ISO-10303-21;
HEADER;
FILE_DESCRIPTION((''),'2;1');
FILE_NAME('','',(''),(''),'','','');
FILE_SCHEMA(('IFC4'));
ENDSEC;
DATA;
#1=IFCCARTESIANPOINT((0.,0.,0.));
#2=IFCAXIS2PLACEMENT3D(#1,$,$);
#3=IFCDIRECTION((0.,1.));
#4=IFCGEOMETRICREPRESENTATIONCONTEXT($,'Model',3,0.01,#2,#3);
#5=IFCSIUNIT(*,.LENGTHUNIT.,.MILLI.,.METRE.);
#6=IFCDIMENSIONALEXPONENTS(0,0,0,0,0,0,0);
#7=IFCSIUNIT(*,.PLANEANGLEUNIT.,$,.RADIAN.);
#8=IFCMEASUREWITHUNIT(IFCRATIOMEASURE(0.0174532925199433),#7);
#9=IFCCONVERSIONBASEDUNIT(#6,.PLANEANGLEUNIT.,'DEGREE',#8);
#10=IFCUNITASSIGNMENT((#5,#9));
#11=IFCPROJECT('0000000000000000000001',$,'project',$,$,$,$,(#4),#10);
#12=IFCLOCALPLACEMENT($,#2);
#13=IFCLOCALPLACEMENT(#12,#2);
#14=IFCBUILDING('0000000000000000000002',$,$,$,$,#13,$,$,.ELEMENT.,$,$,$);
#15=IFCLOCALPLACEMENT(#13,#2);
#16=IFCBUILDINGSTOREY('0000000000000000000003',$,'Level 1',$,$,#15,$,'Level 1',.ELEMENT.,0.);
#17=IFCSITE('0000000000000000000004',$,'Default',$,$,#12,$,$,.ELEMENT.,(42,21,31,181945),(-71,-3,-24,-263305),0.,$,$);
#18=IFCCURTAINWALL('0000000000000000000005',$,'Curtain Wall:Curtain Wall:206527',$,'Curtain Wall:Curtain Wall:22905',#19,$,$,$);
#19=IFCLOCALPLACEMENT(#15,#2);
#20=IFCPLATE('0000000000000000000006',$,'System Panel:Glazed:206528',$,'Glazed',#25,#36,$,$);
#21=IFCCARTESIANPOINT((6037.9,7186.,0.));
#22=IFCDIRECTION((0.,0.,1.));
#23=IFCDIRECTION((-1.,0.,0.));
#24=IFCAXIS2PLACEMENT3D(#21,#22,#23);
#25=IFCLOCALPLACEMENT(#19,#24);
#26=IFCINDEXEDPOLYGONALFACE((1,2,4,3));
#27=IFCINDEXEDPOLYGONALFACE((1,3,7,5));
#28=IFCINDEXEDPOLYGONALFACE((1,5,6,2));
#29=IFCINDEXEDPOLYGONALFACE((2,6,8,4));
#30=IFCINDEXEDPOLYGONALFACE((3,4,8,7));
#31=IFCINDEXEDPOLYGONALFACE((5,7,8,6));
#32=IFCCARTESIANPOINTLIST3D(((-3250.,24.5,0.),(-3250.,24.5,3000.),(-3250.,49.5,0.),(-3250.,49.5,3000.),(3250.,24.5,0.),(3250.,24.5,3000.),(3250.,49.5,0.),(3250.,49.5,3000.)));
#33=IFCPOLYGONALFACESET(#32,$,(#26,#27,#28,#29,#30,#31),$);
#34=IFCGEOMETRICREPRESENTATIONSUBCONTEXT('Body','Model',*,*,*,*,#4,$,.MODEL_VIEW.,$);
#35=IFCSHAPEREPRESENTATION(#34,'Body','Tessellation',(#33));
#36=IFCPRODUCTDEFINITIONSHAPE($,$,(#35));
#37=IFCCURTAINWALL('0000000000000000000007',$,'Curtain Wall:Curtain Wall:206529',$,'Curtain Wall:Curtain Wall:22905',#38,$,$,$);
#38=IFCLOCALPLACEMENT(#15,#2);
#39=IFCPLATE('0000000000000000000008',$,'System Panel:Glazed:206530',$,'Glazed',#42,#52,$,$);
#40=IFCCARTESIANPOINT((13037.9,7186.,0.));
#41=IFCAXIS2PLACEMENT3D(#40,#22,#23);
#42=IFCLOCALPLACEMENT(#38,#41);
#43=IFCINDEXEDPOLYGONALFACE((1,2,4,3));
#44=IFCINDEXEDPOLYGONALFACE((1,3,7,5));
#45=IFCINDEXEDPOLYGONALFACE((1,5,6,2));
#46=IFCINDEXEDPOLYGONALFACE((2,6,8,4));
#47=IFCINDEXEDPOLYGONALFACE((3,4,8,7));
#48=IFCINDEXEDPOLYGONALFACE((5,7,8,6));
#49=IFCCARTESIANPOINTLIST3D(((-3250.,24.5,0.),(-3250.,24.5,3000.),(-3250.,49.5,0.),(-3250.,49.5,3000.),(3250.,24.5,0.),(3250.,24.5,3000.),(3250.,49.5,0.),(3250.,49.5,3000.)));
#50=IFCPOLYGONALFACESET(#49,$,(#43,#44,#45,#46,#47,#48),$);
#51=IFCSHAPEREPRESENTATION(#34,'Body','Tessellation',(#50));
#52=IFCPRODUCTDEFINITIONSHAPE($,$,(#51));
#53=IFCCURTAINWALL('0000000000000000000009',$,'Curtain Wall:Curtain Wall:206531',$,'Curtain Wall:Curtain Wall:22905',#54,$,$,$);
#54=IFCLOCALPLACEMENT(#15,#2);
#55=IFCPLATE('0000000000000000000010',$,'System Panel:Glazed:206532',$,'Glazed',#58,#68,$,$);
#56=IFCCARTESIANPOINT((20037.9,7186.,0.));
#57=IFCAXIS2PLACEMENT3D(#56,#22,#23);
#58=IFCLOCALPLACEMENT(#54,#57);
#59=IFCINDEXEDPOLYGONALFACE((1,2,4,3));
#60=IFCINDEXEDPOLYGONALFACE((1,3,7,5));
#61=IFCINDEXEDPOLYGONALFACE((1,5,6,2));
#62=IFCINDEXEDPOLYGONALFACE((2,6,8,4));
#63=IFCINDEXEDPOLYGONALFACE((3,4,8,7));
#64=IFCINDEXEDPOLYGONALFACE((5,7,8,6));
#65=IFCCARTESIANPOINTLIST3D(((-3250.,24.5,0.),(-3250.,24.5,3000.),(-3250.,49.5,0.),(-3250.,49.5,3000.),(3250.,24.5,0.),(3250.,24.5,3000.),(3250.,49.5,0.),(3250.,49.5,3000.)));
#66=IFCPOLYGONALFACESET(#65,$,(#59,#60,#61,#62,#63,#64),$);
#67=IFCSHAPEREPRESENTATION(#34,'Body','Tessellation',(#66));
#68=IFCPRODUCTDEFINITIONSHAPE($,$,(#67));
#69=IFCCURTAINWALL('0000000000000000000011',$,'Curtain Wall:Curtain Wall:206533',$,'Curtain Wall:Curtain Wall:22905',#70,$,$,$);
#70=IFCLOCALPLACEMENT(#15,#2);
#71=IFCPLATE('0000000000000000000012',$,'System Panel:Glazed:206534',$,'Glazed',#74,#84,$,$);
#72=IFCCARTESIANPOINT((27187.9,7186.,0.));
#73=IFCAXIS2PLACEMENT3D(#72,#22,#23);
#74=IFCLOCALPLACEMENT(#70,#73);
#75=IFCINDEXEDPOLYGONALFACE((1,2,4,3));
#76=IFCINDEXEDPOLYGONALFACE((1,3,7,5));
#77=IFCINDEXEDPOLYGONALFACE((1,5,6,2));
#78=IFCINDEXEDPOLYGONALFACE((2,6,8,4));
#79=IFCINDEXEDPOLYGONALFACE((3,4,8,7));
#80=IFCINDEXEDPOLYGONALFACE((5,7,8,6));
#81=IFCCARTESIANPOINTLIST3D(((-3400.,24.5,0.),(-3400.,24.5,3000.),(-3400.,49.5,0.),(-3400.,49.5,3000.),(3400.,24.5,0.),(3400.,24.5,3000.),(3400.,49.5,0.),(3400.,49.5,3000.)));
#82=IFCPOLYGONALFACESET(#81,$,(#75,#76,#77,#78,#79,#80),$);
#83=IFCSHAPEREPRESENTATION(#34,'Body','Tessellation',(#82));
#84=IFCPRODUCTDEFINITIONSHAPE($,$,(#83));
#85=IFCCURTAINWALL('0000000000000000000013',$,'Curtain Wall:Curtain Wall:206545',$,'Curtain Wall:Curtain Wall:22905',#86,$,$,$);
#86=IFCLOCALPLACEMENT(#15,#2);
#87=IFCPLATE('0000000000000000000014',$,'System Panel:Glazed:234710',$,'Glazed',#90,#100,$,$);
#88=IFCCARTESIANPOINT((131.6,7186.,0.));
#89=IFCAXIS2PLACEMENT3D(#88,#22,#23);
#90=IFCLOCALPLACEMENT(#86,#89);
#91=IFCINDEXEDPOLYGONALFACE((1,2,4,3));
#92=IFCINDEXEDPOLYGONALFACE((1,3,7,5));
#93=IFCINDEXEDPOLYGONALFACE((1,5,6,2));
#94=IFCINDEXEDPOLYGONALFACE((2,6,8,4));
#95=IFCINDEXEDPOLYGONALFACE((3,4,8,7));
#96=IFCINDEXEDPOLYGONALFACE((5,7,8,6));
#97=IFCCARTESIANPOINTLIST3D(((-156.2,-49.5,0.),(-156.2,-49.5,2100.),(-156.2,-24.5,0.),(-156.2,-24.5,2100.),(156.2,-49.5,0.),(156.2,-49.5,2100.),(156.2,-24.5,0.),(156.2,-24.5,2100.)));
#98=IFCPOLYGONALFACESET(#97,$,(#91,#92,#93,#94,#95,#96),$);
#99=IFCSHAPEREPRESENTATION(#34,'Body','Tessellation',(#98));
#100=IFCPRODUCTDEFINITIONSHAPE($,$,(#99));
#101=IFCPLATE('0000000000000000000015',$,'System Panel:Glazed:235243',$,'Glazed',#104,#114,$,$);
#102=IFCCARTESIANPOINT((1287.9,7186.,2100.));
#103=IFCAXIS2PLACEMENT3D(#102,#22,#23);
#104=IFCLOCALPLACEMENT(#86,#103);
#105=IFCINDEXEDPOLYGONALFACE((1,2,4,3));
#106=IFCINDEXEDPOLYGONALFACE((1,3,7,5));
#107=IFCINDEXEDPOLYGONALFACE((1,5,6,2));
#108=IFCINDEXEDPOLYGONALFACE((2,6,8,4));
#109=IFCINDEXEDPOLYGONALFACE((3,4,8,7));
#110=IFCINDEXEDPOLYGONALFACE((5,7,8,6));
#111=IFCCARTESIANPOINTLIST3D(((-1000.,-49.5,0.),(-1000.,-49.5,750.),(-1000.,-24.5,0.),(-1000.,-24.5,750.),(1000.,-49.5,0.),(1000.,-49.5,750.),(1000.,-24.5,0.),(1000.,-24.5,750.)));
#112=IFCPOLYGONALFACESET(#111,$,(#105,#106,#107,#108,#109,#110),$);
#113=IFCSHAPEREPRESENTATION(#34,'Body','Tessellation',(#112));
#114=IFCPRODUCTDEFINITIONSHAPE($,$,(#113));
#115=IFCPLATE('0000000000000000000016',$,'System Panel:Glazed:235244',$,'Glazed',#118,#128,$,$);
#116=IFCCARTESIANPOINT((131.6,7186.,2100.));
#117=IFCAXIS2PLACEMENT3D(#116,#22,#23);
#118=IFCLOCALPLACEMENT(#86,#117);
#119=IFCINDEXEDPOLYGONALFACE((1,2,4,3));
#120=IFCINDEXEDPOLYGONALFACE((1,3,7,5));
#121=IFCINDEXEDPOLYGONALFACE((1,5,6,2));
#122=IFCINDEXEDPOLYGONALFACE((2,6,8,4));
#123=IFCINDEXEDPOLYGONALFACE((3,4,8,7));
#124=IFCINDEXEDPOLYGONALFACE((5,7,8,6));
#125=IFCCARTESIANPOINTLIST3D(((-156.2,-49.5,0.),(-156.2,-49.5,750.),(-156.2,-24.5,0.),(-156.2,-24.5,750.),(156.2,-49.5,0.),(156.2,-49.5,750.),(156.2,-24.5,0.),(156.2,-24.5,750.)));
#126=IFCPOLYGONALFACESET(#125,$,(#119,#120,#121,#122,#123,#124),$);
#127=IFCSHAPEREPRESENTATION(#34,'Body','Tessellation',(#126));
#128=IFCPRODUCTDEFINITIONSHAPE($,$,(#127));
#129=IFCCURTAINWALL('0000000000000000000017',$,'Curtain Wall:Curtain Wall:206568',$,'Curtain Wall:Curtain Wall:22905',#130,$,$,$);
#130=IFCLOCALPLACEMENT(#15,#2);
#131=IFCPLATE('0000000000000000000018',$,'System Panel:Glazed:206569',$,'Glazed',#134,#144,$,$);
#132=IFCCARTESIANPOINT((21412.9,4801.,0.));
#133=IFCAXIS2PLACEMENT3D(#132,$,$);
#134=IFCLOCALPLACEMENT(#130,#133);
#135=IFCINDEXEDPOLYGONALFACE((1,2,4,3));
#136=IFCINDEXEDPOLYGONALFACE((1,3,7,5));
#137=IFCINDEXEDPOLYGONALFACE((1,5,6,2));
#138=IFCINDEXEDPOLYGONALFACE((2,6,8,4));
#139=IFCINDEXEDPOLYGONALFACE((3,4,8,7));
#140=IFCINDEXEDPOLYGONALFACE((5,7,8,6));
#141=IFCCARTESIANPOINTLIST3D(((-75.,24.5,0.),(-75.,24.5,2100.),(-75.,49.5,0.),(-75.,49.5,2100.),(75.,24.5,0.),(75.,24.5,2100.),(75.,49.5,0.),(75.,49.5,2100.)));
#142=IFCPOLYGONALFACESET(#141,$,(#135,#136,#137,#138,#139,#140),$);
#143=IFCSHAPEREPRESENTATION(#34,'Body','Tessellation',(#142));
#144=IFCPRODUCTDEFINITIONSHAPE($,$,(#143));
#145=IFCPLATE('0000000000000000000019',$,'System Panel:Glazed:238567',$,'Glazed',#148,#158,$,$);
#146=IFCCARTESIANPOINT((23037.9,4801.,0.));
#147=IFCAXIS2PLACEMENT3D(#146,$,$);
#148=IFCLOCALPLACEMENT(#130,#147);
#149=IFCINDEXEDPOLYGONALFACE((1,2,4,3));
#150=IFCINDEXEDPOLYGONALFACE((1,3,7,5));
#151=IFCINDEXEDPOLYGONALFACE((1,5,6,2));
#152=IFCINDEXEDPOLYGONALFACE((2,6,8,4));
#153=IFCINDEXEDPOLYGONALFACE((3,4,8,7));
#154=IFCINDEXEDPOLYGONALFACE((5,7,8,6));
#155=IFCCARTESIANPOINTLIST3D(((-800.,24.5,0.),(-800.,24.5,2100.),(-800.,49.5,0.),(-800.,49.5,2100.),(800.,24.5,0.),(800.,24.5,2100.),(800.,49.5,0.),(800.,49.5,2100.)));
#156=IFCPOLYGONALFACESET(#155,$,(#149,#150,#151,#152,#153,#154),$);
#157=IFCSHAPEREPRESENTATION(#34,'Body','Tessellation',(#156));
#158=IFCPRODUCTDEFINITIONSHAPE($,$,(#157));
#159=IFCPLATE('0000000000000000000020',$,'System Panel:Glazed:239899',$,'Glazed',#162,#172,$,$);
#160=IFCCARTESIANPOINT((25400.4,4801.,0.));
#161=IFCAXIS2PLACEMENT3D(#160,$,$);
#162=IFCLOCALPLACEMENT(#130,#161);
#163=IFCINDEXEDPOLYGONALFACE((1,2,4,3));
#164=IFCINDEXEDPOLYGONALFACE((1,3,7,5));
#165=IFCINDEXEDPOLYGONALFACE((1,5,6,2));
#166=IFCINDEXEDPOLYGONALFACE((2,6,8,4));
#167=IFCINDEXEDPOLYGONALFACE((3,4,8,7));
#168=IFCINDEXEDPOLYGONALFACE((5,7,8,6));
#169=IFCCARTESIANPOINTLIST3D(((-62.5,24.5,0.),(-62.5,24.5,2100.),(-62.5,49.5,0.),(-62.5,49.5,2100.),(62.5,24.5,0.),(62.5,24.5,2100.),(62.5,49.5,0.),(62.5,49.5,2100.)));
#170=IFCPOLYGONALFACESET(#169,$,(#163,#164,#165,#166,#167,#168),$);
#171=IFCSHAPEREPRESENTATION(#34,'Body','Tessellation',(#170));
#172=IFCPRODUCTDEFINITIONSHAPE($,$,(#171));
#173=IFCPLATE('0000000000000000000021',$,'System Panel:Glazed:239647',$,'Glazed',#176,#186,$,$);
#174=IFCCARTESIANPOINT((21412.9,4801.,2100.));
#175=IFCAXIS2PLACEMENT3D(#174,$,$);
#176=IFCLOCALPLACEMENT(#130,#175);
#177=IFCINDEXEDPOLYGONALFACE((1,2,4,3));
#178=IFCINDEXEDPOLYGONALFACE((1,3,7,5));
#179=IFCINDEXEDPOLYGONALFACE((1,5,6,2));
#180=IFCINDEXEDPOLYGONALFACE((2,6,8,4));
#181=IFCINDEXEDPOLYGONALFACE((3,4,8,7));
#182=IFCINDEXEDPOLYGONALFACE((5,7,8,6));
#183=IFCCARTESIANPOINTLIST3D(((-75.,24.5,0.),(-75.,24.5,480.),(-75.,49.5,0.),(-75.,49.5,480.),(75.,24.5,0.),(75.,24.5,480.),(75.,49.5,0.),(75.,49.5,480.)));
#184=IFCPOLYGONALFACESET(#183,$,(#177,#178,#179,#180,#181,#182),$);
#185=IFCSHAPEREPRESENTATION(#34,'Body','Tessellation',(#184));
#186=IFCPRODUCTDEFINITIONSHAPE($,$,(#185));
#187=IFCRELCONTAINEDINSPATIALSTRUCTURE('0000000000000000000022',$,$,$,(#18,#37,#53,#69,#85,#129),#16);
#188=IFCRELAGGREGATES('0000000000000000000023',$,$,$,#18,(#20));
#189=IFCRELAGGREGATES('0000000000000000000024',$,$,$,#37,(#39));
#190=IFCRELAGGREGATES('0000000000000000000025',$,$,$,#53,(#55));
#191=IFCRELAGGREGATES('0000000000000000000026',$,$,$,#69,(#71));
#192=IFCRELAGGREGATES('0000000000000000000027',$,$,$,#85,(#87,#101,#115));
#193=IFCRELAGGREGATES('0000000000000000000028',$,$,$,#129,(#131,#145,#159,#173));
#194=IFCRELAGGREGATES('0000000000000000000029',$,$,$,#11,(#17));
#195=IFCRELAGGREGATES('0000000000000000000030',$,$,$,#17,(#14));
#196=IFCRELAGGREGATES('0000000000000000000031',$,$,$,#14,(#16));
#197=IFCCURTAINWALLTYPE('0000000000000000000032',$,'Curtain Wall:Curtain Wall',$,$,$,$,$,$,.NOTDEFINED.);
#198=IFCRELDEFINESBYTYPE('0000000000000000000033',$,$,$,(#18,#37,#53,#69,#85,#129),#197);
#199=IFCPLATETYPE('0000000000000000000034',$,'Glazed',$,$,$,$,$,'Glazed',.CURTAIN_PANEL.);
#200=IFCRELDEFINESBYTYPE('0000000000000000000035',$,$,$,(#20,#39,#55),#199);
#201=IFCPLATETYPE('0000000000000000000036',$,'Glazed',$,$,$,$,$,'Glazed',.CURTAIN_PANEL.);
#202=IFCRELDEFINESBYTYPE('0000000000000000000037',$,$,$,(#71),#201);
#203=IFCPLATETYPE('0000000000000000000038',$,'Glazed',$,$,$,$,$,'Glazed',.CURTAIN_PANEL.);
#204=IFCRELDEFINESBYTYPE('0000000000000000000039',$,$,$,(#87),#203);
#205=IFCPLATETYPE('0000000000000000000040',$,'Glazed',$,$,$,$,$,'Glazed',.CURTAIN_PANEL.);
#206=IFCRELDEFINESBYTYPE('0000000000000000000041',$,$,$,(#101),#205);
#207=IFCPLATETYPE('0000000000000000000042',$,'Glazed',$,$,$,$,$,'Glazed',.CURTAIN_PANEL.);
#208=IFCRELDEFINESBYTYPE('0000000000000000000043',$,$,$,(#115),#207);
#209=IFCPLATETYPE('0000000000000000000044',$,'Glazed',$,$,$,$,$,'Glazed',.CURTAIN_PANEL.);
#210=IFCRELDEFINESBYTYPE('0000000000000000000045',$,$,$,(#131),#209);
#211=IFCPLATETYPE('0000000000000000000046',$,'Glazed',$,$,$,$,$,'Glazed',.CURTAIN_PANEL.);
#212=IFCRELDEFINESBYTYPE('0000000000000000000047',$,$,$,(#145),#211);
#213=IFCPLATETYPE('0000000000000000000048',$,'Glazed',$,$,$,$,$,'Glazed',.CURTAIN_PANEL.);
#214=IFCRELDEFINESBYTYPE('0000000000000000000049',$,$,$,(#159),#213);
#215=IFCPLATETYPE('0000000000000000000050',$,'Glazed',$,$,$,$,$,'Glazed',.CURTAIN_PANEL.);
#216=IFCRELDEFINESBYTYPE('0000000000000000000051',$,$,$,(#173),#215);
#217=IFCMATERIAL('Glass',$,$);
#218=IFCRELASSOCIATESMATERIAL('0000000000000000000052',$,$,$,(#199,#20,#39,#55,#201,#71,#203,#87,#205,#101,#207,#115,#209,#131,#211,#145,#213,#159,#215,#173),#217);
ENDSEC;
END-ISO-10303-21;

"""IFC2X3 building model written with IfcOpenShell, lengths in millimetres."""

from ifc_helpers import new_model, entity, si_unit, converted_unit, direction, frame, frame_2d, origin, origin_2d_with_axis, place, context, subcontext, project, spatial, rectangle, extrude, source, transform, mapped, material, type_object, type_shapes, element, aggregate, save


model = new_model("IFC2X3")

# Units and contexts
model_context = context("Model", 3, precision=0.01, world=origin(), true_north=direction((0.0, 1.0)))
body_context = subcontext(model_context, "Body", "Model", "MODEL_VIEW")
ifc_project = project(units=[si_unit("LENGTHUNIT", "METRE", prefix="MILLI"), converted_unit("PLANEANGLEUNIT", "DEGREE", entity("IfcRatioMeasure", 0.0174532925199433), si_unit("PLANEANGLEUNIT", "RADIAN"), dimensions=[0, 0, 0, 0, 0, 0, 0])], contexts=[model_context])

# Site, building, storey
site_placement = place(None, origin())
site = spatial("IfcSite", under=ifc_project, at=site_placement, Name="Default", CompositionType="ELEMENT", RefLatitude=(42, 21, 31, 181945), RefLongitude=(-71, -3, -24, -263305), RefElevation=0.0)
building_placement = place(site_placement, origin())
building = spatial("IfcBuilding", under=site, at=building_placement, CompositionType="ELEMENT")
storey_placement = place(building_placement, origin())
storey = spatial("IfcBuildingStorey", under=building, at=storey_placement, Name="Level 1", LongName="Level 1", CompositionType="ELEMENT", Elevation=0.0)

# Curtain walls, plates
curtain_wall_type = type_object("IfcCurtainWallType", Name="Curtain Wall:Curtain Wall", PredefinedType="NOTDEFINED")
curtain_wall_1_placement = place(storey_placement, origin())
curtain_wall_1 = element("IfcCurtainWall", 1, at=curtain_wall_1_placement, inside=storey, type_object=curtain_wall_type, Name="Curtain Wall:Curtain Wall:206527", ObjectType="Curtain Wall:Curtain Wall:22905")
ifc_material_1 = material(Name="Glass")
plate_type_1 = type_object("IfcPlateType", Name="Glazed", ElementType="Glazed", PredefinedType="CURTAIN_PANEL", material=ifc_material_1)
shared_shape_1 = source(origin(), body_context, "Body", "SweptSolid", [
    extrude(rectangle(XDim=25.0, YDim=6500.0, at=origin_2d_with_axis()), frame((0.0, 37.0, 0.0), z_axis=(0.0, 0.0, 1.0), x_axis=(0.0, 1.0, 0.0)), (0.0, 0.0, 1.0), 3000.0),
])
type_shapes(plate_type_1, [shared_shape_1])
plate_1_placement = place(curtain_wall_1_placement, frame((6037.9, 7186.0, 0.0), z_axis=(0.0, 0.0, 1.0), x_axis=(-1.0, 0.0, 0.0)))
plate_1 = element("IfcPlate", 2, at=plate_1_placement, type_object=plate_type_1, material=ifc_material_1, Name="System Panel:Glazed:206528", ObjectType="Glazed", context=body_context, shape_type="MappedRepresentation", body=[
    mapped(shared_shape_1, transform((0.0, 0.0, 0.0), scale=1.0)),
])
aggregate(curtain_wall_1, [plate_1])
curtain_wall_2_placement = place(storey_placement, origin())
curtain_wall_2 = element("IfcCurtainWall", 3, at=curtain_wall_2_placement, inside=storey, type_object=curtain_wall_type, Name="Curtain Wall:Curtain Wall:206529", ObjectType="Curtain Wall:Curtain Wall:22905")
plate_2_placement = place(curtain_wall_2_placement, frame((13037.9, 7186.0, 0.0), z_axis=(0.0, 0.0, 1.0), x_axis=(-1.0, 0.0, 0.0)))
plate_2 = element("IfcPlate", 4, at=plate_2_placement, type_object=plate_type_1, material=ifc_material_1, Name="System Panel:Glazed:206530", ObjectType="Glazed", context=body_context, shape_type="MappedRepresentation", body=[
    mapped(shared_shape_1, transform((0.0, 0.0, 0.0), scale=1.0)),
])
aggregate(curtain_wall_2, [plate_2])
curtain_wall_3_placement = place(storey_placement, origin())
curtain_wall_3 = element("IfcCurtainWall", 5, at=curtain_wall_3_placement, inside=storey, type_object=curtain_wall_type, Name="Curtain Wall:Curtain Wall:206531", ObjectType="Curtain Wall:Curtain Wall:22905")
plate_3_placement = place(curtain_wall_3_placement, frame((20037.9, 7186.0, 0.0), z_axis=(0.0, 0.0, 1.0), x_axis=(-1.0, 0.0, 0.0)))
plate_3 = element("IfcPlate", 6, at=plate_3_placement, type_object=plate_type_1, material=ifc_material_1, Name="System Panel:Glazed:206532", ObjectType="Glazed", context=body_context, shape_type="MappedRepresentation", body=[
    mapped(shared_shape_1, transform((0.0, 0.0, 0.0), scale=1.0)),
])
aggregate(curtain_wall_3, [plate_3])
curtain_wall_4_placement = place(storey_placement, origin())
curtain_wall_4 = element("IfcCurtainWall", 7, at=curtain_wall_4_placement, inside=storey, type_object=curtain_wall_type, Name="Curtain Wall:Curtain Wall:206533", ObjectType="Curtain Wall:Curtain Wall:22905")
plate_type_2 = type_object("IfcPlateType", Name="Glazed", ElementType="Glazed", PredefinedType="CURTAIN_PANEL", material=ifc_material_1)
shared_shape_2 = source(origin(), body_context, "Body", "SweptSolid", [
    extrude(rectangle(XDim=25.0, YDim=6800.0, at=origin_2d_with_axis()), frame((0.0, 37.0, 0.0), z_axis=(0.0, 0.0, 1.0), x_axis=(0.0, 1.0, 0.0)), (0.0, 0.0, 1.0), 3000.0),
])
type_shapes(plate_type_2, [shared_shape_2])
plate_4_placement = place(curtain_wall_4_placement, frame((27187.9, 7186.0, 0.0), z_axis=(0.0, 0.0, 1.0), x_axis=(-1.0, 0.0, 0.0)))
plate_4 = element("IfcPlate", 8, at=plate_4_placement, type_object=plate_type_2, material=ifc_material_1, Name="System Panel:Glazed:206534", ObjectType="Glazed", context=body_context, shape_type="MappedRepresentation", body=[
    mapped(shared_shape_2, transform((0.0, 0.0, 0.0), scale=1.0)),
])
aggregate(curtain_wall_4, [plate_4])

# Curtain walls, plates
curtain_wall_5_placement = place(storey_placement, origin())
curtain_wall_5 = element("IfcCurtainWall", 9, at=curtain_wall_5_placement, inside=storey, type_object=curtain_wall_type, Name="Curtain Wall:Curtain Wall:206545", ObjectType="Curtain Wall:Curtain Wall:22905")
plate_type_3 = type_object("IfcPlateType", Name="Glazed", ElementType="Glazed", PredefinedType="CURTAIN_PANEL", material=ifc_material_1)
shared_shape_3 = source(origin(), body_context, "Body", "SweptSolid", [
    extrude(rectangle(XDim=25.0, YDim=312.5, at=frame_2d((0.0, 0.0), x_axis=(1.0, 0.0))), frame((0.0, -37.0, 0.0), z_axis=(0.0, 0.0, 1.0), x_axis=(0.0, 1.0, 0.0)), (0.0, 0.0, 1.0), 2100.0),
])
type_shapes(plate_type_3, [shared_shape_3])
plate_5_placement = place(curtain_wall_5_placement, frame((131.6, 7186.0, 0.0), z_axis=(0.0, 0.0, 1.0), x_axis=(-1.0, 0.0, 0.0)))
plate_5 = element("IfcPlate", 10, at=plate_5_placement, type_object=plate_type_3, material=ifc_material_1, Name="System Panel:Glazed:234710", ObjectType="Glazed", context=body_context, shape_type="MappedRepresentation", body=[
    mapped(shared_shape_3, transform((0.0, 0.0, 0.0), scale=1.0)),
])
plate_type_4 = type_object("IfcPlateType", Name="Glazed", ElementType="Glazed", PredefinedType="CURTAIN_PANEL", material=ifc_material_1)
shared_shape_4 = source(origin(), body_context, "Body", "SweptSolid", [
    extrude(rectangle(XDim=25.0, YDim=2000.0, at=frame_2d((0.0, 0.0), x_axis=(1.0, 0.0))), frame((0.0, -37.0, 0.0), z_axis=(0.0, 0.0, 1.0), x_axis=(0.0, 1.0, 0.0)), (0.0, 0.0, 1.0), 750.0),
])
type_shapes(plate_type_4, [shared_shape_4])
plate_6_placement = place(curtain_wall_5_placement, frame((1287.9, 7186.0, 2100.0), z_axis=(0.0, 0.0, 1.0), x_axis=(-1.0, 0.0, 0.0)))
plate_6 = element("IfcPlate", 11, at=plate_6_placement, type_object=plate_type_4, material=ifc_material_1, Name="System Panel:Glazed:235243", ObjectType="Glazed", context=body_context, shape_type="MappedRepresentation", body=[
    mapped(shared_shape_4, transform((0.0, 0.0, 0.0), scale=1.0)),
])
plate_type_5 = type_object("IfcPlateType", Name="Glazed", ElementType="Glazed", PredefinedType="CURTAIN_PANEL", material=ifc_material_1)
shared_shape_5 = source(origin(), body_context, "Body", "SweptSolid", [
    extrude(rectangle(XDim=25.0, YDim=312.5, at=frame_2d((0.0, 0.0), x_axis=(1.0, 0.0))), frame((0.0, -37.0, 0.0), z_axis=(0.0, 0.0, 1.0), x_axis=(0.0, 1.0, 0.0)), (0.0, 0.0, 1.0), 750.0),
])
type_shapes(plate_type_5, [shared_shape_5])
plate_7_placement = place(curtain_wall_5_placement, frame((131.6, 7186.0, 2100.0), z_axis=(0.0, 0.0, 1.0), x_axis=(-1.0, 0.0, 0.0)))
plate_7 = element("IfcPlate", 12, at=plate_7_placement, type_object=plate_type_5, material=ifc_material_1, Name="System Panel:Glazed:235244", ObjectType="Glazed", context=body_context, shape_type="MappedRepresentation", body=[
    mapped(shared_shape_5, transform((0.0, 0.0, 0.0), scale=1.0)),
])
curtain_wall_6_placement = place(storey_placement, origin())
curtain_wall_6 = element("IfcCurtainWall", 13, at=curtain_wall_6_placement, inside=storey, type_object=curtain_wall_type, Name="Curtain Wall:Curtain Wall:206568", ObjectType="Curtain Wall:Curtain Wall:22905")
plate_type_6 = type_object("IfcPlateType", Name="Glazed", ElementType="Glazed", PredefinedType="CURTAIN_PANEL", material=ifc_material_1)
shared_shape_6 = source(origin(), body_context, "Body", "SweptSolid", [
    extrude(rectangle(XDim=25.0, YDim=150.0, at=origin_2d_with_axis()), frame((0.0, 37.0, 0.0), z_axis=(0.0, 0.0, 1.0), x_axis=(0.0, 1.0, 0.0)), (0.0, 0.0, 1.0), 2100.0),
])
type_shapes(plate_type_6, [shared_shape_6])
plate_8_placement = place(curtain_wall_6_placement, frame((21412.9, 4801.0, 0.0)))
plate_8 = element("IfcPlate", 14, at=plate_8_placement, type_object=plate_type_6, material=ifc_material_1, Name="System Panel:Glazed:206569", ObjectType="Glazed", context=body_context, shape_type="MappedRepresentation", body=[
    mapped(shared_shape_6, transform((0.0, 0.0, 0.0), scale=1.0)),
])
plate_type_7 = type_object("IfcPlateType", Name="Glazed", ElementType="Glazed", PredefinedType="CURTAIN_PANEL", material=ifc_material_1)
shared_shape_7 = source(origin(), body_context, "Body", "SweptSolid", [
    extrude(rectangle(XDim=25.0, YDim=1600.0, at=origin_2d_with_axis()), frame((0.0, 37.0, 0.0), z_axis=(0.0, 0.0, 1.0), x_axis=(0.0, 1.0, 0.0)), (0.0, 0.0, 1.0), 2100.0),
])
type_shapes(plate_type_7, [shared_shape_7])
plate_9_placement = place(curtain_wall_6_placement, frame((23037.9, 4801.0, 0.0)))
plate_9 = element("IfcPlate", 15, at=plate_9_placement, type_object=plate_type_7, material=ifc_material_1, Name="System Panel:Glazed:238567", ObjectType="Glazed", context=body_context, shape_type="MappedRepresentation", body=[
    mapped(shared_shape_7, transform((0.0, 0.0, 0.0), scale=1.0)),
])
plate_type_8 = type_object("IfcPlateType", Name="Glazed", ElementType="Glazed", PredefinedType="CURTAIN_PANEL", material=ifc_material_1)
shared_shape_8 = source(origin(), body_context, "Body", "SweptSolid", [
    extrude(rectangle(XDim=25.0, YDim=125.0, at=origin_2d_with_axis()), frame((0.0, 37.0, 0.0), z_axis=(0.0, 0.0, 1.0), x_axis=(0.0, 1.0, 0.0)), (0.0, 0.0, 1.0), 2100.0),
])
type_shapes(plate_type_8, [shared_shape_8])
plate_10_placement = place(curtain_wall_6_placement, frame((25400.4, 4801.0, 0.0)))
plate_10 = element("IfcPlate", 16, at=plate_10_placement, type_object=plate_type_8, material=ifc_material_1, Name="System Panel:Glazed:239899", ObjectType="Glazed", context=body_context, shape_type="MappedRepresentation", body=[
    mapped(shared_shape_8, transform((0.0, 0.0, 0.0), scale=1.0)),
])
plate_type_9 = type_object("IfcPlateType", Name="Glazed", ElementType="Glazed", PredefinedType="CURTAIN_PANEL", material=ifc_material_1)
shared_shape_9 = source(origin(), body_context, "Body", "SweptSolid", [
    extrude(rectangle(XDim=25.0, YDim=150.0, at=origin_2d_with_axis()), frame((0.0, 37.0, 0.0), z_axis=(0.0, 0.0, 1.0), x_axis=(0.0, 1.0, 0.0)), (0.0, 0.0, 1.0), 480.0),
])
type_shapes(plate_type_9, [shared_shape_9])
plate_11_placement = place(curtain_wall_6_placement, frame((21412.9, 4801.0, 2100.0)))
plate_11 = element("IfcPlate", 17, at=plate_11_placement, type_object=plate_type_9, material=ifc_material_1, Name="System Panel:Glazed:239647", ObjectType="Glazed", context=body_context, shape_type="MappedRepresentation", body=[
    mapped(shared_shape_9, transform((0.0, 0.0, 0.0), scale=1.0)),
])

aggregate(curtain_wall_5, [plate_5, plate_6, plate_7])
aggregate(curtain_wall_6, [plate_8, plate_9, plate_10, plate_11])

save(model, "model.ifc")
